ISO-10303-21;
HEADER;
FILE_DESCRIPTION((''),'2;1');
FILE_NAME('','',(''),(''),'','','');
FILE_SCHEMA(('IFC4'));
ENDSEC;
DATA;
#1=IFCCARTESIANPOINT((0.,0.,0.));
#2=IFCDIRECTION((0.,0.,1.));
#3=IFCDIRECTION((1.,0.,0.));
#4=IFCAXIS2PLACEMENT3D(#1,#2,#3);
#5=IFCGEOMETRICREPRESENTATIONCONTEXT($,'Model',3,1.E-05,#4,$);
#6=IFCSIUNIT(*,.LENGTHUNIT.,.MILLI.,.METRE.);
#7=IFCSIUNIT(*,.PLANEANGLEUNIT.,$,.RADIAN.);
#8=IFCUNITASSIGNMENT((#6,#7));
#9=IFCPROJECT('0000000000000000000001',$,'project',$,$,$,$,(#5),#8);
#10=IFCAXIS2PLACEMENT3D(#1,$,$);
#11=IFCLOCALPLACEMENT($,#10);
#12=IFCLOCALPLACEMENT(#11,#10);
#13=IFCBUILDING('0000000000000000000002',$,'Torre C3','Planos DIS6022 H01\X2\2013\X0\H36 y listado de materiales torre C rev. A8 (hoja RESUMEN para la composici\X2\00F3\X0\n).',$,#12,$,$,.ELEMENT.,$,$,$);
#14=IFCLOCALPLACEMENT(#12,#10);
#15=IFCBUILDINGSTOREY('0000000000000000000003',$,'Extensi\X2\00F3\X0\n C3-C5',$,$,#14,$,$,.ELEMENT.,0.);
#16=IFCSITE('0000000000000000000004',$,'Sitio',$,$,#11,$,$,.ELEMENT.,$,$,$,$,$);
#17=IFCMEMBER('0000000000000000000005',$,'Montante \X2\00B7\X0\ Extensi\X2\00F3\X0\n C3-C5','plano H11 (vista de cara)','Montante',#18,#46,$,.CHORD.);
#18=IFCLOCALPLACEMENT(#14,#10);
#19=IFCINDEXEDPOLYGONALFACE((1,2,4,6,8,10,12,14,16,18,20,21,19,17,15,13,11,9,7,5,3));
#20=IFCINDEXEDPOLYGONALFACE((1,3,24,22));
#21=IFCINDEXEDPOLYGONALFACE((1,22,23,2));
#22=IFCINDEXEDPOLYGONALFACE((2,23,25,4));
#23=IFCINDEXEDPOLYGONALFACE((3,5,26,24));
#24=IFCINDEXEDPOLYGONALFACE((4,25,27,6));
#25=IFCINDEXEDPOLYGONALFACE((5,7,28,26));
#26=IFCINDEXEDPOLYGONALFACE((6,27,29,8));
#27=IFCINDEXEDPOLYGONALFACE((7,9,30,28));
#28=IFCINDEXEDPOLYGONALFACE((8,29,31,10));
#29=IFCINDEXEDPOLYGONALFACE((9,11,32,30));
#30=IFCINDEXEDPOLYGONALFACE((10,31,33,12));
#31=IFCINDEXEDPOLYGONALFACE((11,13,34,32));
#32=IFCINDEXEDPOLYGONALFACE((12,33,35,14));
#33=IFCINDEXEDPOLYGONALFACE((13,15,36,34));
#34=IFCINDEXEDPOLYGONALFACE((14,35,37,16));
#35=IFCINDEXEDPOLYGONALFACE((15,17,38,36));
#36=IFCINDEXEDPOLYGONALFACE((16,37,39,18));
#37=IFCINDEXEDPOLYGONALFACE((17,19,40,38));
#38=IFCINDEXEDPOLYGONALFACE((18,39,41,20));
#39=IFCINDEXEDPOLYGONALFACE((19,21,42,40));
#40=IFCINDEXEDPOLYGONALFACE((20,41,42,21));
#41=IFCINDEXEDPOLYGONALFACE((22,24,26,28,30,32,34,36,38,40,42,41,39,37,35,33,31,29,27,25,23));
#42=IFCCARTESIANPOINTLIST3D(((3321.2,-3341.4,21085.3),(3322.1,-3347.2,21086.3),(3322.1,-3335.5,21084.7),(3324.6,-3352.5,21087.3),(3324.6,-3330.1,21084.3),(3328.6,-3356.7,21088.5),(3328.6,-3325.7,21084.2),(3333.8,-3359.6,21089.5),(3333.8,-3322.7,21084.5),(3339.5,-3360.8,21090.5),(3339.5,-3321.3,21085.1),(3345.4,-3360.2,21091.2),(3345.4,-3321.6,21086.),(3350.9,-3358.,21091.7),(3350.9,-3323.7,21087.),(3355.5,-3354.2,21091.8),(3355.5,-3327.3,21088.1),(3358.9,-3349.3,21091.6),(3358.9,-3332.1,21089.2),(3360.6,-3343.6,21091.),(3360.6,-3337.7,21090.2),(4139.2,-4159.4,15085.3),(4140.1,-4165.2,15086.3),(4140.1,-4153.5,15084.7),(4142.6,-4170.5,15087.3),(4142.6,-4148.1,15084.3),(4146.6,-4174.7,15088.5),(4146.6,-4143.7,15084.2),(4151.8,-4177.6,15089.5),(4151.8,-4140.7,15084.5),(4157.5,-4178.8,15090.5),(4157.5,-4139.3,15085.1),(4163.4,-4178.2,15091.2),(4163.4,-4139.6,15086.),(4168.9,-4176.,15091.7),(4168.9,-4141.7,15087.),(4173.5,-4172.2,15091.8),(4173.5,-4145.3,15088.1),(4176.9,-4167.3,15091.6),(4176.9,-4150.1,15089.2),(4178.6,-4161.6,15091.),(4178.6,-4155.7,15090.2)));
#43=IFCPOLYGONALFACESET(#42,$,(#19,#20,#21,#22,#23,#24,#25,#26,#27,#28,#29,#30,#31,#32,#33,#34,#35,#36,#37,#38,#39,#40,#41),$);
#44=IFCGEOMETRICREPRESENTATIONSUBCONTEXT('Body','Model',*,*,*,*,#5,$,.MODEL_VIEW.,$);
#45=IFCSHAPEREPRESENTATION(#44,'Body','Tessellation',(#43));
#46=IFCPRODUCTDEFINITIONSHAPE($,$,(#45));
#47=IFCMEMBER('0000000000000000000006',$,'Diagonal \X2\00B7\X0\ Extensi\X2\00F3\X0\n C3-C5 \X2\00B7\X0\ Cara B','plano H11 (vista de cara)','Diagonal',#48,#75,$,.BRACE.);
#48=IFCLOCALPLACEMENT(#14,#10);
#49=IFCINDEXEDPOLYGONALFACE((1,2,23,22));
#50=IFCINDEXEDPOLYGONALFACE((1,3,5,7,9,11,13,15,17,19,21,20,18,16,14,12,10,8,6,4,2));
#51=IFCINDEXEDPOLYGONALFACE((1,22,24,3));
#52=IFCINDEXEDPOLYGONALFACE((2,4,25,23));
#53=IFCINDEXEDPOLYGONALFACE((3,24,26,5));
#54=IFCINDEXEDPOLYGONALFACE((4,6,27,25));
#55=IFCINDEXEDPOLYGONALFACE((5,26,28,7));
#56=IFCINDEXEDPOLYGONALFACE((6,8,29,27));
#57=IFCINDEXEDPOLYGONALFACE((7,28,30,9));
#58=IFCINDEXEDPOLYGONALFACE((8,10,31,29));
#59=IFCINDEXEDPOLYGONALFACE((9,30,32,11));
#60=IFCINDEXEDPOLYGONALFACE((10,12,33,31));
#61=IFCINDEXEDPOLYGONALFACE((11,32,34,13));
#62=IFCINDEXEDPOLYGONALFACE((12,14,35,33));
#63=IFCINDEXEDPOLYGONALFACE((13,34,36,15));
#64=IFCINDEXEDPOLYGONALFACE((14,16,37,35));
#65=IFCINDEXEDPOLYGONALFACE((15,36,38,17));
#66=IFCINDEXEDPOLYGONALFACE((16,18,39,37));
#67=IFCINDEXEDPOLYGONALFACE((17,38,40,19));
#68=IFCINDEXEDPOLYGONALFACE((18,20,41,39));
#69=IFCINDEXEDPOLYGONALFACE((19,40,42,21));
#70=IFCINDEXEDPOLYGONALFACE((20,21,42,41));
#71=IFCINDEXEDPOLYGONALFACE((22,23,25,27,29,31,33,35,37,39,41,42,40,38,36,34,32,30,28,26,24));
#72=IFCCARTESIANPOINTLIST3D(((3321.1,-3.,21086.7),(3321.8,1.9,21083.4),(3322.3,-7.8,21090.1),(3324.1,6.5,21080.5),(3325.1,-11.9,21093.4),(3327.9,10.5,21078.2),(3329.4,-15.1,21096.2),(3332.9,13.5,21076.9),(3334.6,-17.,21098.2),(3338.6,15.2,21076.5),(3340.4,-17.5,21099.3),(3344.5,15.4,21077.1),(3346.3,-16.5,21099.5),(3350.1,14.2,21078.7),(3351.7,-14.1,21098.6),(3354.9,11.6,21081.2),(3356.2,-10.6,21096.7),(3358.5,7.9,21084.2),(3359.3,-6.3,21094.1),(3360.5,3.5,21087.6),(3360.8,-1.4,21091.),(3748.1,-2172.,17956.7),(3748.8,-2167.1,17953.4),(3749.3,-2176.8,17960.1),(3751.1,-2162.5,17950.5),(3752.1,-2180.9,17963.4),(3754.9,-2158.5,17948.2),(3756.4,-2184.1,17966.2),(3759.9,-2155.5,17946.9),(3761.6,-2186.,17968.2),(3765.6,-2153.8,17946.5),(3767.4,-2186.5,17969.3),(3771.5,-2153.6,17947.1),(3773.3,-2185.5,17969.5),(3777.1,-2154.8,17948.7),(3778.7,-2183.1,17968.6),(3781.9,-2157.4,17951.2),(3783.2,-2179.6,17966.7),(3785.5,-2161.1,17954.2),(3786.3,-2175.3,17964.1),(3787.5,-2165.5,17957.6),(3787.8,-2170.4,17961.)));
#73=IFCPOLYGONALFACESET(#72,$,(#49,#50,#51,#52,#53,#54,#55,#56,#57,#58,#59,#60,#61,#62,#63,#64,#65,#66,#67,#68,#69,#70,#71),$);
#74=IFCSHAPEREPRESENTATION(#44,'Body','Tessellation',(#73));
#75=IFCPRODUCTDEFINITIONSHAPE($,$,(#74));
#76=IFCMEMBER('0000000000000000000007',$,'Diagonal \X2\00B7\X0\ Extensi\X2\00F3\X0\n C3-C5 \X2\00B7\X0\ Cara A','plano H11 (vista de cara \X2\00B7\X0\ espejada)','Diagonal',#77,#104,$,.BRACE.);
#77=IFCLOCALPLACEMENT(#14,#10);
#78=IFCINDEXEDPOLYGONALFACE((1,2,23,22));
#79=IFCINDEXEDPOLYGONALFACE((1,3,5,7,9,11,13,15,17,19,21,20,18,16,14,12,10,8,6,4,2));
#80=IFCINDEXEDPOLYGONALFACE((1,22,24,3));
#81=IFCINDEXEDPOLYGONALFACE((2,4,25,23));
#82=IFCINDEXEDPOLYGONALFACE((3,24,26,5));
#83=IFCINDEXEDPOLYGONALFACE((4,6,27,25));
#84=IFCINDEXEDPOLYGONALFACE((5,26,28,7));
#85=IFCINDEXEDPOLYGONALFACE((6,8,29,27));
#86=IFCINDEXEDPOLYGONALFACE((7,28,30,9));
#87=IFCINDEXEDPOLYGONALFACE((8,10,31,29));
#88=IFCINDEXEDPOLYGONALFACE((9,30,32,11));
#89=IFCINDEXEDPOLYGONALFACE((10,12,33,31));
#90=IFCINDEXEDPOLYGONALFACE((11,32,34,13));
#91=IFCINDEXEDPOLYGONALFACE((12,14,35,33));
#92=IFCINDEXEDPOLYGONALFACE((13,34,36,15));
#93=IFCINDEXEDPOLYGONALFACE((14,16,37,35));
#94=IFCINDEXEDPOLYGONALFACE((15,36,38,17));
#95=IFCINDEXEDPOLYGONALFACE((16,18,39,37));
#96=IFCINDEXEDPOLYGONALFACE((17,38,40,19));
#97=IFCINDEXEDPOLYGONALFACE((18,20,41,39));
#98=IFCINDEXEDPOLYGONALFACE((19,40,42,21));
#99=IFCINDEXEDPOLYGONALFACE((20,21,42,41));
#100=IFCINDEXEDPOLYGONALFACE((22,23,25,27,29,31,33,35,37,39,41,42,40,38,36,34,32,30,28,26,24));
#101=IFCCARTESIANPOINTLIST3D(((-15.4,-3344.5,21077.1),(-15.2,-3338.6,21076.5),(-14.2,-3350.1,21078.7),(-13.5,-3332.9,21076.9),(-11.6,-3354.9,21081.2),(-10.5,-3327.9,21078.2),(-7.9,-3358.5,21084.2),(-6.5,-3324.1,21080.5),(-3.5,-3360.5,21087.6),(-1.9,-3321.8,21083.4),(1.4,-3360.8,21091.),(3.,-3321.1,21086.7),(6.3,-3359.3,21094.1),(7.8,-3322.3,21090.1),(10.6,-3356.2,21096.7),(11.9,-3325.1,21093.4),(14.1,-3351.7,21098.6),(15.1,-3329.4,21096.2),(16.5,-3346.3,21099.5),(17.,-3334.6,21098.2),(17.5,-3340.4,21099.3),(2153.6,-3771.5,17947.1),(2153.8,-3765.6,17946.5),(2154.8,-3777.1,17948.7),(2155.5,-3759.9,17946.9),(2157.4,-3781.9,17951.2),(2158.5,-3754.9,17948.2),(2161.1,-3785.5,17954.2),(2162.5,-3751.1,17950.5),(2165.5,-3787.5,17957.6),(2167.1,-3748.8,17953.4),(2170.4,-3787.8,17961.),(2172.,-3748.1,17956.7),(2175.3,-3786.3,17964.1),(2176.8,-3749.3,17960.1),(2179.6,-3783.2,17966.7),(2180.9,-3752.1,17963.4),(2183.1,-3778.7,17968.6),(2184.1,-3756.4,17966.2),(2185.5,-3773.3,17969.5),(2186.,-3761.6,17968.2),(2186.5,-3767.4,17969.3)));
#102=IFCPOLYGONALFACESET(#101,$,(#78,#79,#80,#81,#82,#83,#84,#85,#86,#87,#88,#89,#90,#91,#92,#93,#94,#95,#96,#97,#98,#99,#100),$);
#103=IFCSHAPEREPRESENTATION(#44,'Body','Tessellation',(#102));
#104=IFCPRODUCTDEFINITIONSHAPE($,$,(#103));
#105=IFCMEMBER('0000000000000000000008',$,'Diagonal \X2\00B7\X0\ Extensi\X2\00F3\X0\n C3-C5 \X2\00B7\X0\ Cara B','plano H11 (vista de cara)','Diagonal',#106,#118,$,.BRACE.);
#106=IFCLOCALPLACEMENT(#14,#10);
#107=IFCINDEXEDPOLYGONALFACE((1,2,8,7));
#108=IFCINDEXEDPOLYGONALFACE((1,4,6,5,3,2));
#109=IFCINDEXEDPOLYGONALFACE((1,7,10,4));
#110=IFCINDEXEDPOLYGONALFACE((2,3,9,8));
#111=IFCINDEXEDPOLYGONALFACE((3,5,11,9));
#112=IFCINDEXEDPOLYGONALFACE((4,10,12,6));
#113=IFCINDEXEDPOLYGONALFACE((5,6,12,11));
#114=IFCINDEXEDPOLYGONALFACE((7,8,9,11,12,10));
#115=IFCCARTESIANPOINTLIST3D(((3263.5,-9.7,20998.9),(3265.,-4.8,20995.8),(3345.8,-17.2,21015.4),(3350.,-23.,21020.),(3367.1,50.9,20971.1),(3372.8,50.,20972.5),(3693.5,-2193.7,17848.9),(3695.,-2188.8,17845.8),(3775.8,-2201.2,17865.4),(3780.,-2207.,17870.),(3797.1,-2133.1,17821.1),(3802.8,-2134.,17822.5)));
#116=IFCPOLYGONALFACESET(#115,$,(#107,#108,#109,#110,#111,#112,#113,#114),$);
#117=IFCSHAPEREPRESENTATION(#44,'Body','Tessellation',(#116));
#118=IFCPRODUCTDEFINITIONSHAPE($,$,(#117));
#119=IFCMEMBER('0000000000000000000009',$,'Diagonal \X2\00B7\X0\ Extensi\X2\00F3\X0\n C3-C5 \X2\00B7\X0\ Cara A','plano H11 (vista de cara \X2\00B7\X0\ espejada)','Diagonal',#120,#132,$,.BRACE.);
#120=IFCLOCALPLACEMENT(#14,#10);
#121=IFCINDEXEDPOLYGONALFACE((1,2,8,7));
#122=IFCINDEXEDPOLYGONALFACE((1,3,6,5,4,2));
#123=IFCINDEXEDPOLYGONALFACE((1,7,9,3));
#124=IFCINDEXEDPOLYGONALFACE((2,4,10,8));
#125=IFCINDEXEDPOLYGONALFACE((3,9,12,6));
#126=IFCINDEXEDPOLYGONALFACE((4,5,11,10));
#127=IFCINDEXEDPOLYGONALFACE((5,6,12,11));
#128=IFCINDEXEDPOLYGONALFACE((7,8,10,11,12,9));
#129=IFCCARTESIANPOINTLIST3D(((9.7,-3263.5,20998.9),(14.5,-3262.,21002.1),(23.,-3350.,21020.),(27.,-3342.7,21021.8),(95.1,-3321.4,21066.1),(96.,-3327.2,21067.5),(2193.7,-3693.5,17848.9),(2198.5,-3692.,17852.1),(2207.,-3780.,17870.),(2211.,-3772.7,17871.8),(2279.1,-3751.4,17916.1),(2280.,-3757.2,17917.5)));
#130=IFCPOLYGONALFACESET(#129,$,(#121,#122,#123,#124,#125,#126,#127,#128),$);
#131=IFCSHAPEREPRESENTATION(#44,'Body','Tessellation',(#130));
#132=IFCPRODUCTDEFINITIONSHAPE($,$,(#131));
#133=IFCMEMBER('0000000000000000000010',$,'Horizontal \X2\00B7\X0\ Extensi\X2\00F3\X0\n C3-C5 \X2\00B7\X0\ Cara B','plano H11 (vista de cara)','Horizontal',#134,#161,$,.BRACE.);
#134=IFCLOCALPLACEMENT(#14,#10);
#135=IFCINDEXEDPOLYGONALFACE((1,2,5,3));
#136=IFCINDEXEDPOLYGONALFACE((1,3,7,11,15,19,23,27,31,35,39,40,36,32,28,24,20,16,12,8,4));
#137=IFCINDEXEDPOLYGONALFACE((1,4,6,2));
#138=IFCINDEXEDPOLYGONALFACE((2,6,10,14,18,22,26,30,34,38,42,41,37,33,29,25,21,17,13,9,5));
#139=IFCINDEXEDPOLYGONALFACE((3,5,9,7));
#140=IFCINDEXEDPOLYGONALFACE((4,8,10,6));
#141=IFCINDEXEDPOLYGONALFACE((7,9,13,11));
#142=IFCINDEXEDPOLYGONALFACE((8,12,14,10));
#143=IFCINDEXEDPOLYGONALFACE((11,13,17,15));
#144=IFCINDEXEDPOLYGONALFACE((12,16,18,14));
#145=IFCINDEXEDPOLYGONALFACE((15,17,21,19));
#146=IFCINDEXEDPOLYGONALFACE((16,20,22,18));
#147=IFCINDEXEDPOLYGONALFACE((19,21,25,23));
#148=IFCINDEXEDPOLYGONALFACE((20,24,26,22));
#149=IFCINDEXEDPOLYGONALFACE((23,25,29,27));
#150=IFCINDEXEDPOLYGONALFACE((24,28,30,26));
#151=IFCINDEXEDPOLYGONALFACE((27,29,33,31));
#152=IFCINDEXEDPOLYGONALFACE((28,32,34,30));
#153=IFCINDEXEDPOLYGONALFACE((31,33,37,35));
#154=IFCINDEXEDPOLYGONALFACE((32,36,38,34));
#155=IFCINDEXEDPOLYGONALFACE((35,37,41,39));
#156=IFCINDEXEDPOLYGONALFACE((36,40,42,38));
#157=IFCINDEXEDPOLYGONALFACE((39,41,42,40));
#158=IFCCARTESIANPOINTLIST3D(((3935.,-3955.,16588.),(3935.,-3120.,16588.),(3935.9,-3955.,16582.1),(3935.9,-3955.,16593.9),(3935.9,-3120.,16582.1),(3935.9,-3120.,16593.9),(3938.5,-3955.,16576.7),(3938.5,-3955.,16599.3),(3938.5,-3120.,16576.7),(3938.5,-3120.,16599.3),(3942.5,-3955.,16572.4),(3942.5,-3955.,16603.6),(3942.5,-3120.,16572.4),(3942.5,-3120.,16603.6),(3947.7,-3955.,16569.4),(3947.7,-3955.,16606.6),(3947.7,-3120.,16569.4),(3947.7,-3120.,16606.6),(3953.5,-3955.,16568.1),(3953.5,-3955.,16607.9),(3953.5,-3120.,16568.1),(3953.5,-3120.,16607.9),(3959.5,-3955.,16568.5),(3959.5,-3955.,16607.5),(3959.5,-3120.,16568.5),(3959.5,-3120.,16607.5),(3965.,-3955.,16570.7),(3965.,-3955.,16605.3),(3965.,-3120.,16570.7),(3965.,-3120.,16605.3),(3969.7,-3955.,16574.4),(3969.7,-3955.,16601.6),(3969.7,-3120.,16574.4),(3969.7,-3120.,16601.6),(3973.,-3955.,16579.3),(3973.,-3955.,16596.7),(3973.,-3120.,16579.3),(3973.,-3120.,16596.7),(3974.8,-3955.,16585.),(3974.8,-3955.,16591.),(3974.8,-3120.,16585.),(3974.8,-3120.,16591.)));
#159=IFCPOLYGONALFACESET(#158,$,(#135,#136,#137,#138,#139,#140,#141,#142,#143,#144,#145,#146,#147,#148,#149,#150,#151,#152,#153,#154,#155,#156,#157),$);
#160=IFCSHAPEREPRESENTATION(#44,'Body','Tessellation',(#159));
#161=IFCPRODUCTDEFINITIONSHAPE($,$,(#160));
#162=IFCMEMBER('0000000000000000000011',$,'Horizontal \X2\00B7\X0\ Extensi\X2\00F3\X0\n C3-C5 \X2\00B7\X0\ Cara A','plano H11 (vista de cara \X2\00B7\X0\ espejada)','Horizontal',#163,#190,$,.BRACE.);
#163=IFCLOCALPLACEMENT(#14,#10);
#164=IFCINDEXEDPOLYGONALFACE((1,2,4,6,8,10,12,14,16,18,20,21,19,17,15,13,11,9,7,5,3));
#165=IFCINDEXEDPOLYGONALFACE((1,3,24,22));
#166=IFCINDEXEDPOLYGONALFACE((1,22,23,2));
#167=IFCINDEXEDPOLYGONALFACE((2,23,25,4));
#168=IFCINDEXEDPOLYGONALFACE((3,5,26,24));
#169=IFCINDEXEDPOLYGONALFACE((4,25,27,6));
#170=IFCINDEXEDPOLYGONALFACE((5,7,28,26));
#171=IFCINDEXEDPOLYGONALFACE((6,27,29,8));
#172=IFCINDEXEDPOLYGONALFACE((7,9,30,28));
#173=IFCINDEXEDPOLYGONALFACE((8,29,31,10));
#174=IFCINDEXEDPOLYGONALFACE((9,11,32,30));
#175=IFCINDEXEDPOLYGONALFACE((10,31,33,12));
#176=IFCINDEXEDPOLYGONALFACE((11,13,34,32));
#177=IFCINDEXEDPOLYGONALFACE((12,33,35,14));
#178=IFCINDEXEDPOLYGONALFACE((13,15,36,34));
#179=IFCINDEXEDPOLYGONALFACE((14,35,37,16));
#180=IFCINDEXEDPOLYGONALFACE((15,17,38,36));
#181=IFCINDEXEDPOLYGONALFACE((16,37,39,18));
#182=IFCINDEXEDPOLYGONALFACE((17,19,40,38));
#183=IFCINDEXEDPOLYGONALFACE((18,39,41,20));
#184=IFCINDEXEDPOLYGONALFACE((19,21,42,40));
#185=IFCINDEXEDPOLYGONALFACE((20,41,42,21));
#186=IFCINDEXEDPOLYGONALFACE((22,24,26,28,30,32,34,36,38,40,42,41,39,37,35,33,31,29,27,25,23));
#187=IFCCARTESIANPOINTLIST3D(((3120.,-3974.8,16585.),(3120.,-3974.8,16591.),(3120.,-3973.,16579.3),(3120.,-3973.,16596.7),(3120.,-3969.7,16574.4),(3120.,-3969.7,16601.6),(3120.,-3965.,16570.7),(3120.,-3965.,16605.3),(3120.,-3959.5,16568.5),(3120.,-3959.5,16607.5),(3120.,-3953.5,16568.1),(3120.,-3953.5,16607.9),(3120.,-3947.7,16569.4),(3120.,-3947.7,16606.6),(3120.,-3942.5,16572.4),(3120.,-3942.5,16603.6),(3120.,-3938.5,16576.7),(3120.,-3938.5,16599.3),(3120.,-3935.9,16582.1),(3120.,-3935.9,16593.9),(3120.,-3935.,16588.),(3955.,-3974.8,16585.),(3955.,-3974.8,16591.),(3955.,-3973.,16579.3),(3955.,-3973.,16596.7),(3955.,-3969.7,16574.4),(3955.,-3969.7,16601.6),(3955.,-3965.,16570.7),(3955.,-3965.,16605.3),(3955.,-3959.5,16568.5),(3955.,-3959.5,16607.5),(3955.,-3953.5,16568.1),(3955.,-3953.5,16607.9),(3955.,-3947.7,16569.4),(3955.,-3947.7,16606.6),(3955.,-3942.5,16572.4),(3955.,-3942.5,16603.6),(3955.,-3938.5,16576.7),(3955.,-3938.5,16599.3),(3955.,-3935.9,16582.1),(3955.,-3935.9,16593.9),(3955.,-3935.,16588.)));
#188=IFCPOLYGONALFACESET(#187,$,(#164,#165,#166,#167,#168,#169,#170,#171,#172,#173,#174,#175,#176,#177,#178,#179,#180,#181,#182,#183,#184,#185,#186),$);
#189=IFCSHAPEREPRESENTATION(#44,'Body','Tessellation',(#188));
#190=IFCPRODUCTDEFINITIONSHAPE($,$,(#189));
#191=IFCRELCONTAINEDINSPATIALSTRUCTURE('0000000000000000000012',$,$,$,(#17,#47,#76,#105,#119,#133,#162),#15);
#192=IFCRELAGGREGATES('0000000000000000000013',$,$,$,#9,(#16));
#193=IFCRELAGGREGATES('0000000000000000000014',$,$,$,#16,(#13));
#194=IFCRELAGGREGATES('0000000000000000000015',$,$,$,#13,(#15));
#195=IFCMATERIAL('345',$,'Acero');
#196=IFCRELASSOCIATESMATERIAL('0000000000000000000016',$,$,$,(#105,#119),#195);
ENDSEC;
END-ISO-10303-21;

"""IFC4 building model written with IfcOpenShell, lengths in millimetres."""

from ifc_helpers import new_model, si_unit, frame, frame_2d, origin, origin_with_axes, place, context, subcontext, project, spatial, circle, l_section, extrude, material, element, save


model = new_model("IFC4")

# Units and contexts
model_context = context("Model", 3, precision=1e-05, world=origin_with_axes())
body_context = subcontext(model_context, "Body", "Model", "MODEL_VIEW")
ifc_project = project(units=[si_unit("LENGTHUNIT", "METRE", prefix="MILLI"), si_unit("PLANEANGLEUNIT", "RADIAN")], contexts=[model_context])

# Site, building, storey
site_placement = place(None, origin())
site = spatial("IfcSite", under=ifc_project, at=site_placement, Name="Sitio", CompositionType="ELEMENT")
building_placement = place(site_placement, origin())
building = spatial("IfcBuilding", under=site, at=building_placement, Name="Torre C3", Description="Planos DIS6022 H01–H36 y listado de materiales torre C rev. A8 (hoja RESUMEN para la composición).", CompositionType="ELEMENT")
storey_placement = place(building_placement, origin())
storey = spatial("IfcBuildingStorey", under=building, at=storey_placement, Name="Extensión C3-C5", CompositionType="ELEMENT", Elevation=0.0)

# Members
member_placement = place(storey_placement, frame((3341.0, -3341.0, 21088.0), z_axis=(0.133868, -0.133868, -0.981916), x_axis=(-0.990999, -0.018083, -0.132641)))
element("IfcMember", 1, at=member_placement, inside=storey, Name="Montante · Extensión C3-C5", Description="plano H11 (vista de cara)", ObjectType="Montante", PredefinedType="CHORD", context=body_context, shape_type="SweptSolid", body=[
    extrude(circle(Radius=20.0), None, (0.0, 0.0, 1.0), 6110.5),
])
for number, where, z_axis, x_axis, name, description in (
    (2, (3341.0, -1.0, 21088.0), (0.111432, -0.566031, -0.816818), (-0.962353, 0.14358, -0.230783), "Diagonal · Extensión C3-C5 · Cara B", "plano H11 (vista de cara)"),
    (3, (1.0, -3341.0, 21088.0), (0.566031, -0.111432, -0.816818), (-0.14358, 0.962353, -0.230783), "Diagonal · Extensión C3-C5 · Cara A", "plano H11 (vista de cara · espejada)"),
):
    element("IfcMember", number, at=place(storey_placement, frame(where, z_axis=z_axis, x_axis=x_axis)), inside=storey, Name=name, Description=description, ObjectType="Diagonal", PredefinedType="BRACE", context=body_context, shape_type="SweptSolid", body=[
        extrude(circle(Radius=20.0), None, (0.0, 0.0, 1.0), 3831.9),
    ])
ifc_material_1 = material(Name="345", Category="Acero")
for number, where, z_axis, x_axis, name, description in (
    (4, (3350.0, -23.0, 21020.0), (0.111483, -0.566228, -0.816675), (-0.960867, 0.148288, -0.233979), "Diagonal · Extensión C3-C5 · Cara B", "plano H11 (vista de cara)"),
    (5, (23.0, -3350.0, 21020.0), (0.566228, -0.111483, -0.816675), (-0.148288, 0.960867, -0.233979), "Diagonal · Extensión C3-C5 · Cara A", "plano H11 (vista de cara · espejada)"),
):
    element("IfcMember", number, at=place(storey_placement, frame(where, z_axis=z_axis, x_axis=x_axis)), inside=storey, material=ifc_material_1, Name=name, Description=description, ObjectType="Diagonal", PredefinedType="BRACE", context=body_context, shape_type="SweptSolid", body=[
        extrude(l_section(Depth=90.0, Width=90.0, Thickness=6.0, at=frame_2d((45.0, 45.0))), None, (0.0, 0.0, 1.0), 3857.1),
    ])
for number, where, z_axis, x_axis, name, description in (
    (6, (3955.0, -3120.0, 16588.0), (0.0, -1.0, 0.0), (-1.0, 0.0, 0.0), "Horizontal · Extensión C3-C5 · Cara B", "plano H11 (vista de cara)"),
    (7, (3120.0, -3955.0, 16588.0), (1.0, 0.0, 0.0), (0.0, 1.0, 0.0), "Horizontal · Extensión C3-C5 · Cara A", "plano H11 (vista de cara · espejada)"),
):
    element("IfcMember", number, at=place(storey_placement, frame(where, z_axis=z_axis, x_axis=x_axis)), inside=storey, Name=name, Description=description, ObjectType="Horizontal", PredefinedType="BRACE", context=body_context, shape_type="SweptSolid", body=[
        extrude(circle(Radius=20.0), None, (0.0, 0.0, 1.0), 835.0),
    ])

save(model, "model.ifc")
